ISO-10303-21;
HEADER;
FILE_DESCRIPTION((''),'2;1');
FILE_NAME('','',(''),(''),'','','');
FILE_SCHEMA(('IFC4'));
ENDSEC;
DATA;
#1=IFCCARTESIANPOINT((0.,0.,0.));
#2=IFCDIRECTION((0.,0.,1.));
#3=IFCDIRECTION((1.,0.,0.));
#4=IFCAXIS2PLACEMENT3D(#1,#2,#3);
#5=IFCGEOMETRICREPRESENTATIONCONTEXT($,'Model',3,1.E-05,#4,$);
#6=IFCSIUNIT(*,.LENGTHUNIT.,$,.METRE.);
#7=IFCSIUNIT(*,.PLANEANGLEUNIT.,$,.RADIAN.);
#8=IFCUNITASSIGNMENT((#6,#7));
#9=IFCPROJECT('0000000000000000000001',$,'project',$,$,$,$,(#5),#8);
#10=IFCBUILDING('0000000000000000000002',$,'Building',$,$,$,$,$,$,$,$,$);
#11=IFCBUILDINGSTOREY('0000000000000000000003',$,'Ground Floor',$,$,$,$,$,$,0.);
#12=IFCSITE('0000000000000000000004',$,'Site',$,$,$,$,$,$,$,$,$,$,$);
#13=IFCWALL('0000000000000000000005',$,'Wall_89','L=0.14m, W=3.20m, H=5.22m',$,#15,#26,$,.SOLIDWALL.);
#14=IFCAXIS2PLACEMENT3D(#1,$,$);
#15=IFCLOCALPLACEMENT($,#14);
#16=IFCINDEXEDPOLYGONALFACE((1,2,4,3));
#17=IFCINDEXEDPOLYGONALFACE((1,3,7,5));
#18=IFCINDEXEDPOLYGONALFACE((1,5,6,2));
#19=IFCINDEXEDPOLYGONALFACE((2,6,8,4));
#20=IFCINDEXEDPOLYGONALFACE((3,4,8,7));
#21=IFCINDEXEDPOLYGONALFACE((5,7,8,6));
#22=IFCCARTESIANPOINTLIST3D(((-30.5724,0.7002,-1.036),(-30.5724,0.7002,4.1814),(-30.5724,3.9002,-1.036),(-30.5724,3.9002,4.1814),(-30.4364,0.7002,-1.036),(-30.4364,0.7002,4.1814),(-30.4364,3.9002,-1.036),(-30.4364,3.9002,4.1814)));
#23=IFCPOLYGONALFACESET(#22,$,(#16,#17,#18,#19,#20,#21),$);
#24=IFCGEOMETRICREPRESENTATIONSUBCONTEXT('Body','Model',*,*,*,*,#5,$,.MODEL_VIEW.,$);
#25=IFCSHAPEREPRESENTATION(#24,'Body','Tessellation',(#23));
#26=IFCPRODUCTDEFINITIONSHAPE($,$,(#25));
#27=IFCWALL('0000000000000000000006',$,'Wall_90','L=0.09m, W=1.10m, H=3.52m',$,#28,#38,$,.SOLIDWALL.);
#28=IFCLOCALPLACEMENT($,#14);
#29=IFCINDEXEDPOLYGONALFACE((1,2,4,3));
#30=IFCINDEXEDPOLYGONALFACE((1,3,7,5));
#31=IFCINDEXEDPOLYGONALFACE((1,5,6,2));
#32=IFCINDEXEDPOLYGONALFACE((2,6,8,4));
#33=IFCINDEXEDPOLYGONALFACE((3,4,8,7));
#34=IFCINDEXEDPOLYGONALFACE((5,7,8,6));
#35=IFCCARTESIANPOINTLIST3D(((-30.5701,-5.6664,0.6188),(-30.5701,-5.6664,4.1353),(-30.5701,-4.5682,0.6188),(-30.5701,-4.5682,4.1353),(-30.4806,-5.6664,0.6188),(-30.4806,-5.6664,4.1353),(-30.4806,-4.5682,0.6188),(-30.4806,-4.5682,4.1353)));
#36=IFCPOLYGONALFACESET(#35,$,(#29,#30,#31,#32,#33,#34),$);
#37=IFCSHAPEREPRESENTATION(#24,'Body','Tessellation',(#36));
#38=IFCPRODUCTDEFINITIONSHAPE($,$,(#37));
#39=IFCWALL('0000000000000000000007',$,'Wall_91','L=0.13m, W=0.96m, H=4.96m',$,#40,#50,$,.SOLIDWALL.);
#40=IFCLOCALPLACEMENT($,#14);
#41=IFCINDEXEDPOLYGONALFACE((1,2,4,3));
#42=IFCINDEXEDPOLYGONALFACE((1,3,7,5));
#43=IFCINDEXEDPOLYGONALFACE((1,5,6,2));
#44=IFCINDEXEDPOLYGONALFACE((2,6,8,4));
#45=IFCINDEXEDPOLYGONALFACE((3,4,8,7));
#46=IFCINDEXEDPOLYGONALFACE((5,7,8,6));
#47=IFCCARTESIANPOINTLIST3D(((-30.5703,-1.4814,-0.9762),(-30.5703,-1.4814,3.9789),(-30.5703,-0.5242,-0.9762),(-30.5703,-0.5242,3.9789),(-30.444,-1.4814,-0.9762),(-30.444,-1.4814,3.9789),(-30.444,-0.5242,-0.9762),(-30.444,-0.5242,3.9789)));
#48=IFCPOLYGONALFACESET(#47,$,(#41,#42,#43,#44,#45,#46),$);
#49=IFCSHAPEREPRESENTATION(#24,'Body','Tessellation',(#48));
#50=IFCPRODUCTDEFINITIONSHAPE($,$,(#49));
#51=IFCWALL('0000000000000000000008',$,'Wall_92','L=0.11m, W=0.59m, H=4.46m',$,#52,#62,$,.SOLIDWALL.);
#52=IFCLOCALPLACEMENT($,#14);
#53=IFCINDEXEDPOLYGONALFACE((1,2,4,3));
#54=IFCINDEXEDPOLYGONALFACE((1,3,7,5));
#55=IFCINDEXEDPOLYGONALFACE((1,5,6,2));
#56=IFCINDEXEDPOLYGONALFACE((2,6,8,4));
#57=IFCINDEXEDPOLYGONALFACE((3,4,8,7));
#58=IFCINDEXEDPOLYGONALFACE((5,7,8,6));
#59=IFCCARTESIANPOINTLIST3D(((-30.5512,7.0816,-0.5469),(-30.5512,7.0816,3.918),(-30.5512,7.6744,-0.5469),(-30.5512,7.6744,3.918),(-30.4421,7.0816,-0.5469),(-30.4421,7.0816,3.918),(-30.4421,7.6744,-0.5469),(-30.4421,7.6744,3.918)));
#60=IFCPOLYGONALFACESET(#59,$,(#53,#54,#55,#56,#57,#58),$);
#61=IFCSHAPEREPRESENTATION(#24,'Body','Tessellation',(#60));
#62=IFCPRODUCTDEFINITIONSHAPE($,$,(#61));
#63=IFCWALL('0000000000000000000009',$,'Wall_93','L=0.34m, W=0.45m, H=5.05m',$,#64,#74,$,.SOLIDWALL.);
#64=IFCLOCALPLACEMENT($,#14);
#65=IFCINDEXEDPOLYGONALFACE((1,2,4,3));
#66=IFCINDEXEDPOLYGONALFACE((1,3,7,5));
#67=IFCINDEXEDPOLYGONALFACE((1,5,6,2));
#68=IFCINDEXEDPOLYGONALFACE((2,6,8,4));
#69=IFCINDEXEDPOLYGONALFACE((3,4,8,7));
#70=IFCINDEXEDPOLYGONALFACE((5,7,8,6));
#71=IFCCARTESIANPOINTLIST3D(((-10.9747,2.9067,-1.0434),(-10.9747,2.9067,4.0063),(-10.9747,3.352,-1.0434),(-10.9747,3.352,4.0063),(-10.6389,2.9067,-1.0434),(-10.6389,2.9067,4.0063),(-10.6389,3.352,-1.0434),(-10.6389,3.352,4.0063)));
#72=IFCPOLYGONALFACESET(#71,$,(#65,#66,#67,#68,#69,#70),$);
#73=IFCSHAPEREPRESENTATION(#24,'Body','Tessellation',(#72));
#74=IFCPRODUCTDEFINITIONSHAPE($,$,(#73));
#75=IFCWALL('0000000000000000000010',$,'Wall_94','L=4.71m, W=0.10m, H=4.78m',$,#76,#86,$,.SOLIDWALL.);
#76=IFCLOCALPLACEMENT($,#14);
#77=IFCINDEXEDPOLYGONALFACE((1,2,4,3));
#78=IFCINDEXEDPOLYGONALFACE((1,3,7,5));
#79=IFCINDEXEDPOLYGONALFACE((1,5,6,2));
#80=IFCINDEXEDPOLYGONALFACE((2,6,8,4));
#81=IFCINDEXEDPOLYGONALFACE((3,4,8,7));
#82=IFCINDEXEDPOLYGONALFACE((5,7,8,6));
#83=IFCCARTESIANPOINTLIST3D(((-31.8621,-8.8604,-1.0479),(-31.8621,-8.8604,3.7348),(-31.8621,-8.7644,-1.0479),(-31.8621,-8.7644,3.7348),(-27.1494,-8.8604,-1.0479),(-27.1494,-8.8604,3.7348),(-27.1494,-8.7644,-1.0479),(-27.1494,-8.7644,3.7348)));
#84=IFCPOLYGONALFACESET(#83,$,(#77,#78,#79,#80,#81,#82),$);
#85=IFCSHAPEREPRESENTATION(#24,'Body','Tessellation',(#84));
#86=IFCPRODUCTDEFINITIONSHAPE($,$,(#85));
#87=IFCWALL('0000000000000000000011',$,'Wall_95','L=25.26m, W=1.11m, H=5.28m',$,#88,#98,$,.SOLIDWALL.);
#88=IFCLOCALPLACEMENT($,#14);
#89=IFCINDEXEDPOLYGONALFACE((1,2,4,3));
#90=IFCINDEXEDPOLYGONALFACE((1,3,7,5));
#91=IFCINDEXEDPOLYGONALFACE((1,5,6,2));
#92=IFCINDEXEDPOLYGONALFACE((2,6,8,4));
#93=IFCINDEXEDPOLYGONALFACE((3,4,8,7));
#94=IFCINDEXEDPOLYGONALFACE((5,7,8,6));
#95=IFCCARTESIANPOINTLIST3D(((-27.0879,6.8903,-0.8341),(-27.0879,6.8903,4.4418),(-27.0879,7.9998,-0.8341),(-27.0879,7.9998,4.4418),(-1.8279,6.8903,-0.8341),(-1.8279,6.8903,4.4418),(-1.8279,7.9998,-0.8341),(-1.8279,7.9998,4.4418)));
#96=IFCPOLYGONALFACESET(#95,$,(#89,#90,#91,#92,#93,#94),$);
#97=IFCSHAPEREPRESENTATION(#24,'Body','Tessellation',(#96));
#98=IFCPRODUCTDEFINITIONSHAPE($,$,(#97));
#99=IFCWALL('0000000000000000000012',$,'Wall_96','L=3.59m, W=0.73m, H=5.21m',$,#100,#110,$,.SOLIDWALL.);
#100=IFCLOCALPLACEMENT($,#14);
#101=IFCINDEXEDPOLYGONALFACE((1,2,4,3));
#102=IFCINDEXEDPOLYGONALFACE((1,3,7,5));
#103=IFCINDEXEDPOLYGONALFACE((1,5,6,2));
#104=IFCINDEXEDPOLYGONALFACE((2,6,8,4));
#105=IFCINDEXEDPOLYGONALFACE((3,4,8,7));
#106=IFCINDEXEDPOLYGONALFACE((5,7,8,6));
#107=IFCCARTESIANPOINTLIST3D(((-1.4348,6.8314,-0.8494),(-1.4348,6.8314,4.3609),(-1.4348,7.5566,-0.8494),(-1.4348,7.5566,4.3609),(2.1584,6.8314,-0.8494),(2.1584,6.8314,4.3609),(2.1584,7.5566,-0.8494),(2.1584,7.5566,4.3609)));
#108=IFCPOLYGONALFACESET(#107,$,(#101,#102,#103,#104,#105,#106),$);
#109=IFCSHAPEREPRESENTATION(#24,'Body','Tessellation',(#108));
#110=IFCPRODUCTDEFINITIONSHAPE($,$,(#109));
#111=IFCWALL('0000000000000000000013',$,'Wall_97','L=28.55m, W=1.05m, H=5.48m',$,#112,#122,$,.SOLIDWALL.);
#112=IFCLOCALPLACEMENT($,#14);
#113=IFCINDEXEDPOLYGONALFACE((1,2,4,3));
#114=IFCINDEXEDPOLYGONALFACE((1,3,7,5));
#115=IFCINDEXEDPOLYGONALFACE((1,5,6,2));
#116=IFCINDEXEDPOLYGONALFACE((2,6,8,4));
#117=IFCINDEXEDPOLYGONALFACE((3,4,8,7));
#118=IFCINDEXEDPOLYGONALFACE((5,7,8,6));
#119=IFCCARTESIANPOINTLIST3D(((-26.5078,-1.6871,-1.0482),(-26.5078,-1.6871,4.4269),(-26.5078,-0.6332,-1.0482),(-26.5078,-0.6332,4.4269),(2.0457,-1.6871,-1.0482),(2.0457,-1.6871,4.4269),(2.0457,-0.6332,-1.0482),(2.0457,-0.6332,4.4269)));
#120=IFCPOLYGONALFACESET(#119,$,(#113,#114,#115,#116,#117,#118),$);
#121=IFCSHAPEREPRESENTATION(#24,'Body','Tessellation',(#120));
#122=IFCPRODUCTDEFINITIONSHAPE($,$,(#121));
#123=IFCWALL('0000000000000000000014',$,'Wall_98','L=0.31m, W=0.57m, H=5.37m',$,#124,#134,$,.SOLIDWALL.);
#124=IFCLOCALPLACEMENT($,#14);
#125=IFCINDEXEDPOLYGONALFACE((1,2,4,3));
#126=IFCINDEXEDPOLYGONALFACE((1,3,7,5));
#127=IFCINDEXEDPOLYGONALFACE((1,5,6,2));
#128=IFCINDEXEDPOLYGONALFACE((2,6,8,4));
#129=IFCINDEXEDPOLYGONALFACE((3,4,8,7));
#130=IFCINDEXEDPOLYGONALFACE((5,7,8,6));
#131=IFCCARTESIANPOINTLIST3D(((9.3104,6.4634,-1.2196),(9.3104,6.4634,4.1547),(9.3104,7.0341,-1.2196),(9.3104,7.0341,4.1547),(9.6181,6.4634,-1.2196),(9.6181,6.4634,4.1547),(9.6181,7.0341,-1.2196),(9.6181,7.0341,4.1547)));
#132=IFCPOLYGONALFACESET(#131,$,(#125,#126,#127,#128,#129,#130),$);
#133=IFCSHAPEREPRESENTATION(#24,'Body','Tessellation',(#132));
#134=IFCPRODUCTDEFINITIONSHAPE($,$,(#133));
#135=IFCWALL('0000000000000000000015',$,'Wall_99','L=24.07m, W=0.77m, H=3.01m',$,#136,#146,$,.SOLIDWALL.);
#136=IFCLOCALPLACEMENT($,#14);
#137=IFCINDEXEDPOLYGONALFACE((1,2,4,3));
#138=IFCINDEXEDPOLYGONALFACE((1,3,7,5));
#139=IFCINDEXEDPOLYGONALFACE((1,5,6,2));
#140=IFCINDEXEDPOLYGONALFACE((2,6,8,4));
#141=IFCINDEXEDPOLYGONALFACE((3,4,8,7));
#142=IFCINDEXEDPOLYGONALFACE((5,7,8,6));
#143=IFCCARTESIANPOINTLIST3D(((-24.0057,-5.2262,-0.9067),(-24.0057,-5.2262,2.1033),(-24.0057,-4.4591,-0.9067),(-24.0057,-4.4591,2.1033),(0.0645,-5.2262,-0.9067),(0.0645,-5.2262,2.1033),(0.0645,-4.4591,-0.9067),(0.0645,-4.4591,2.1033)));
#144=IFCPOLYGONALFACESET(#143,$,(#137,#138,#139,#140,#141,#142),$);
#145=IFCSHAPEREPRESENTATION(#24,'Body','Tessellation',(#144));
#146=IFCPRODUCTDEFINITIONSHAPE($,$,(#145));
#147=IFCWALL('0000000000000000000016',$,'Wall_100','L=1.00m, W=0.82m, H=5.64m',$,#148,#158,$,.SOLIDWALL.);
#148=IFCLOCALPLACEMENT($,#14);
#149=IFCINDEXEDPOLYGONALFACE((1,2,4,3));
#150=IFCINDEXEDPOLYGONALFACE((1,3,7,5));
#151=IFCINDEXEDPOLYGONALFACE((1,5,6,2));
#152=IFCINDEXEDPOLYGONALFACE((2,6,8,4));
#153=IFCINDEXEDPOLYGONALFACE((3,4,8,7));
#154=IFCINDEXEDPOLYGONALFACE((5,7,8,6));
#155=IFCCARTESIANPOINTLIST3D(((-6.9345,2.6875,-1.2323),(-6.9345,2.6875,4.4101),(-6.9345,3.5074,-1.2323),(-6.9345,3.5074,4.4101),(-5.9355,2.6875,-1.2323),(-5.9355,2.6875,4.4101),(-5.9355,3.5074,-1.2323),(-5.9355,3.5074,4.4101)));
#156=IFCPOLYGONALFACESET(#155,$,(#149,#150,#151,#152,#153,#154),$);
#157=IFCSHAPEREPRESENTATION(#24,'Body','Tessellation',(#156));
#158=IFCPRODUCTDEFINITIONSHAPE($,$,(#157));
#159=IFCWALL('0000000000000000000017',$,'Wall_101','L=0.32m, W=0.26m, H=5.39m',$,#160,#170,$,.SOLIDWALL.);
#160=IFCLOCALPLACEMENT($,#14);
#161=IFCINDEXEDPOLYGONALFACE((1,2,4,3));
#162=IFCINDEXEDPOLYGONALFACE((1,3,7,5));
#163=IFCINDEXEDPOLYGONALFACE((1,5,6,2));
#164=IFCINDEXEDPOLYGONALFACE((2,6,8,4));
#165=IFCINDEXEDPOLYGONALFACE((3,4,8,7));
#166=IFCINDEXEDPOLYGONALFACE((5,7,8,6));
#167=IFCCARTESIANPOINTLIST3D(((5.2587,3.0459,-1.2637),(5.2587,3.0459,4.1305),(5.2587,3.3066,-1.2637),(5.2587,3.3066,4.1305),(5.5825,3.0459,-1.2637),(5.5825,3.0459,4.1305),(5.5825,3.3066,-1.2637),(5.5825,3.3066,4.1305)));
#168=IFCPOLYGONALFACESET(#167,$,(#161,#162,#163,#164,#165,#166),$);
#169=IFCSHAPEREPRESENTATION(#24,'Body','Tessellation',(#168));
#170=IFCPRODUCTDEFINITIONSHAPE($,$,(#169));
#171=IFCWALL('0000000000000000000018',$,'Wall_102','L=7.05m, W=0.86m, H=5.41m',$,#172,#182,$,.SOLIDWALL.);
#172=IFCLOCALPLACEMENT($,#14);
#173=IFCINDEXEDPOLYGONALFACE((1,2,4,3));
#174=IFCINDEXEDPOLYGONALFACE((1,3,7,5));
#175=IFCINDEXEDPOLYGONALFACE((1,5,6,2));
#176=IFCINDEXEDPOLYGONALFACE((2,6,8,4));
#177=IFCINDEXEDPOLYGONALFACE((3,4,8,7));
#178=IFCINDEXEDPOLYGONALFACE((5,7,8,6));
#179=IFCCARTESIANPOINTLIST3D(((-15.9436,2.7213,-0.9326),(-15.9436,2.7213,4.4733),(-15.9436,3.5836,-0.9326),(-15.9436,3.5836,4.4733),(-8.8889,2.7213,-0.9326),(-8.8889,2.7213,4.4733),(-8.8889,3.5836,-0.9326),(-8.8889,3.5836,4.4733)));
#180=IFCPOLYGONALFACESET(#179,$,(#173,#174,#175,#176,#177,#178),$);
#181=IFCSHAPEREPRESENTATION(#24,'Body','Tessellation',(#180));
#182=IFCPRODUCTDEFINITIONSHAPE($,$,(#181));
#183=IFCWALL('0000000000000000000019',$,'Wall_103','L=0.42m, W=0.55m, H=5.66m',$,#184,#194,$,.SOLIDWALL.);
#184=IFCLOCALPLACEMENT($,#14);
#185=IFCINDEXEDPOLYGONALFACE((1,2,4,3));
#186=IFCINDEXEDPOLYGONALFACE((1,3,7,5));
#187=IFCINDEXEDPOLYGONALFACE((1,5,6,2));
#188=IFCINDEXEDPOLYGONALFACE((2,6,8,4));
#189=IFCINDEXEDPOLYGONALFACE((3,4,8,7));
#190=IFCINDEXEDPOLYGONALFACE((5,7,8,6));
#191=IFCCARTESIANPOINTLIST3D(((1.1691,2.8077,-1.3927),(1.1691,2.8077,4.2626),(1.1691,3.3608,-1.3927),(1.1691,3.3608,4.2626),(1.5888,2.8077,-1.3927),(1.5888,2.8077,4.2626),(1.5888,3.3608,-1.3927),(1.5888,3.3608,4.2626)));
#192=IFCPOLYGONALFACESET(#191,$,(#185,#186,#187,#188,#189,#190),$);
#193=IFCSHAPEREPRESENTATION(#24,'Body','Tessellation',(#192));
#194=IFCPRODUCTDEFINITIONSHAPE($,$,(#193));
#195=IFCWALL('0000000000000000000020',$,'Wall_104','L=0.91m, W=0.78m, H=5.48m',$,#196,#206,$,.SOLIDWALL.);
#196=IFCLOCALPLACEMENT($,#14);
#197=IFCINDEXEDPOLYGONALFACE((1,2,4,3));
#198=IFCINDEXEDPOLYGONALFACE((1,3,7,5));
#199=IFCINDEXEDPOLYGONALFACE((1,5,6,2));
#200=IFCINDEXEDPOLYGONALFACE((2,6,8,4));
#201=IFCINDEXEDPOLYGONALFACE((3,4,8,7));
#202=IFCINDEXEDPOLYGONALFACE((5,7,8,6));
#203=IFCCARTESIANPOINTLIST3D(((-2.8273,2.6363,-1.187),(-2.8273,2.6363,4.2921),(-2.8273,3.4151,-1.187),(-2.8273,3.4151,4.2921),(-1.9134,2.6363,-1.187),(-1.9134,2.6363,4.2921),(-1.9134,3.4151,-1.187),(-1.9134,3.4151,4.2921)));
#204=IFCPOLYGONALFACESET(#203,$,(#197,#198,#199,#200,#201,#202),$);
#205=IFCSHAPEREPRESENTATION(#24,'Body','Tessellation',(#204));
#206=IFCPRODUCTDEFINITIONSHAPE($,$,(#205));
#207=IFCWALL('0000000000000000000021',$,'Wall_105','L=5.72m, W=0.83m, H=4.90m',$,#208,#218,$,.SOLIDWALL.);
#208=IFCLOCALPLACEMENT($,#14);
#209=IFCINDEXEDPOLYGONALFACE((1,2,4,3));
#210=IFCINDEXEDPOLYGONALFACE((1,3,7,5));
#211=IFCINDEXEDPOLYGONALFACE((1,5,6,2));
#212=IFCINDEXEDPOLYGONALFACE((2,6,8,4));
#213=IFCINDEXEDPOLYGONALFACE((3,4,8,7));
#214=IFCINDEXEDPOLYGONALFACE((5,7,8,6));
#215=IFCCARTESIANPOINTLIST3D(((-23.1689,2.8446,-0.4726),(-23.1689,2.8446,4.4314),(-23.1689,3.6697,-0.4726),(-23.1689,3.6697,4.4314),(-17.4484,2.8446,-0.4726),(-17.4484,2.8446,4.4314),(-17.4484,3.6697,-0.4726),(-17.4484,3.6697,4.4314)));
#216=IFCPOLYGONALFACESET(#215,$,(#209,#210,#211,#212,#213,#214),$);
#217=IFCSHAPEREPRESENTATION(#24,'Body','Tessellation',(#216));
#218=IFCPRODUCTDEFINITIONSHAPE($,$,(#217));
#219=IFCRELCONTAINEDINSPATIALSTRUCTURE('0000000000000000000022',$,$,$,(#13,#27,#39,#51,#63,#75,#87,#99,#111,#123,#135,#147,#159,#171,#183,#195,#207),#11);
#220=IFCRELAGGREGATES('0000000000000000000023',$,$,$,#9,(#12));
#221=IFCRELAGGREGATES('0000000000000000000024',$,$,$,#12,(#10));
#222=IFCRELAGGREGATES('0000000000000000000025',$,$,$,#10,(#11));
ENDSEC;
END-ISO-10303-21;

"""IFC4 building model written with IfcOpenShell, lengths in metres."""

from ifc_helpers import new_model, si_unit, frame, origin_with_axes, origin_2d, context, subcontext, project, spatial, rectangle, extrude, element, save


model = new_model("IFC4")

# Units and contexts
model_context = context("Model", 3, precision=1e-05, world=origin_with_axes())
body_context = subcontext(model_context, "Body", "Model", "MODEL_VIEW")
ifc_project = project(units=[si_unit("LENGTHUNIT", "METRE"), si_unit("PLANEANGLEUNIT", "RADIAN")], contexts=[model_context])

# Site, building, storey
site = spatial("IfcSite", under=ifc_project, Name="Site")
building = spatial("IfcBuilding", under=site, Name="Building")
storey = spatial("IfcBuildingStorey", under=building, Name="Ground Floor", Elevation=0.0)

# Walls
element("IfcWall", 1, inside=storey, Name="Wall_89", Description="L=0.14m, W=3.20m, H=5.22m", PredefinedType="SOLIDWALL", context=body_context, shape_type="SweptSolid", body=[
    extrude(rectangle(XDim=0.136, YDim=3.2, at=origin_2d()), frame((-30.5044, 2.3002, -1.036), z_axis=(0.0, 0.0, 1.0), x_axis=(1.0, 0.0, 0.0)), (0.0, 0.0, 1.0), 5.2174),
])
element("IfcWall", 2, inside=storey, Name="Wall_90", Description="L=0.09m, W=1.10m, H=3.52m", PredefinedType="SOLIDWALL", context=body_context, shape_type="SweptSolid", body=[
    extrude(rectangle(XDim=0.0895, YDim=1.0983, at=origin_2d()), frame((-30.5254, -5.1173, 0.6188), z_axis=(0.0, 0.0, 1.0), x_axis=(1.0, 0.0, 0.0)), (0.0, 0.0, 1.0), 3.5166),
])
element("IfcWall", 3, inside=storey, Name="Wall_91", Description="L=0.13m, W=0.96m, H=4.96m", PredefinedType="SOLIDWALL", context=body_context, shape_type="SweptSolid", body=[
    extrude(rectangle(XDim=0.1263, YDim=0.9571, at=origin_2d()), frame((-30.5071, -1.0028, -0.9762), z_axis=(0.0, 0.0, 1.0), x_axis=(1.0, 0.0, 0.0)), (0.0, 0.0, 1.0), 4.9551),
])
element("IfcWall", 4, inside=storey, Name="Wall_92", Description="L=0.11m, W=0.59m, H=4.46m", PredefinedType="SOLIDWALL", context=body_context, shape_type="SweptSolid", body=[
    extrude(rectangle(XDim=0.1091, YDim=0.5928, at=origin_2d()), frame((-30.4967, 7.378, -0.5469), z_axis=(0.0, 0.0, 1.0), x_axis=(1.0, 0.0, 0.0)), (0.0, 0.0, 1.0), 4.4649),
])
element("IfcWall", 5, inside=storey, Name="Wall_93", Description="L=0.34m, W=0.45m, H=5.05m", PredefinedType="SOLIDWALL", context=body_context, shape_type="SweptSolid", body=[
    extrude(rectangle(XDim=0.3358, YDim=0.4454, at=origin_2d()), frame((-10.8068, 3.1293, -1.0434), z_axis=(0.0, 0.0, 1.0), x_axis=(1.0, 0.0, 0.0)), (0.0, 0.0, 1.0), 5.0497),
])
element("IfcWall", 6, inside=storey, Name="Wall_94", Description="L=4.71m, W=0.10m, H=4.78m", PredefinedType="SOLIDWALL", context=body_context, shape_type="SweptSolid", body=[
    extrude(rectangle(XDim=4.7127, YDim=0.0959, at=origin_2d()), frame((-29.5058, -8.8124, -1.0479), z_axis=(0.0, 0.0, 1.0), x_axis=(1.0, 0.0, 0.0)), (0.0, 0.0, 1.0), 4.7827),
])
element("IfcWall", 7, inside=storey, Name="Wall_95", Description="L=25.26m, W=1.11m, H=5.28m", PredefinedType="SOLIDWALL", context=body_context, shape_type="SweptSolid", body=[
    extrude(rectangle(XDim=25.26, YDim=1.1095, at=origin_2d()), frame((-14.4579, 7.4451, -0.8341), z_axis=(0.0, 0.0, 1.0), x_axis=(1.0, 0.0, 0.0)), (0.0, 0.0, 1.0), 5.276),
])
element("IfcWall", 8, inside=storey, Name="Wall_96", Description="L=3.59m, W=0.73m, H=5.21m", PredefinedType="SOLIDWALL", context=body_context, shape_type="SweptSolid", body=[
    extrude(rectangle(XDim=3.5931, YDim=0.7253, at=origin_2d()), frame((0.3618, 7.194, -0.8494), z_axis=(0.0, 0.0, 1.0), x_axis=(1.0, 0.0, 0.0)), (0.0, 0.0, 1.0), 5.2103),
])
element("IfcWall", 9, inside=storey, Name="Wall_97", Description="L=28.55m, W=1.05m, H=5.48m", PredefinedType="SOLIDWALL", context=body_context, shape_type="SweptSolid", body=[
    extrude(rectangle(XDim=28.5534, YDim=1.0539, at=origin_2d()), frame((-12.231, -1.1601, -1.0482), z_axis=(0.0, 0.0, 1.0), x_axis=(1.0, 0.0, 0.0)), (0.0, 0.0, 1.0), 5.4752),
])
element("IfcWall", 10, inside=storey, Name="Wall_98", Description="L=0.31m, W=0.57m, H=5.37m", PredefinedType="SOLIDWALL", context=body_context, shape_type="SweptSolid", body=[
    extrude(rectangle(XDim=0.3077, YDim=0.5707, at=origin_2d()), frame((9.4642, 6.7487, -1.2196), z_axis=(0.0, 0.0, 1.0), x_axis=(1.0, 0.0, 0.0)), (0.0, 0.0, 1.0), 5.3743),
])
element("IfcWall", 11, inside=storey, Name="Wall_99", Description="L=24.07m, W=0.77m, H=3.01m", PredefinedType="SOLIDWALL", context=body_context, shape_type="SweptSolid", body=[
    extrude(rectangle(XDim=24.0702, YDim=0.7671, at=origin_2d()), frame((-11.9706, -4.8426, -0.9067), z_axis=(0.0, 0.0, 1.0), x_axis=(1.0, 0.0, 0.0)), (0.0, 0.0, 1.0), 3.01),
])
element("IfcWall", 12, inside=storey, Name="Wall_100", Description="L=1.00m, W=0.82m, H=5.64m", PredefinedType="SOLIDWALL", context=body_context, shape_type="SweptSolid", body=[
    extrude(rectangle(XDim=0.999, YDim=0.8198, at=origin_2d()), frame((-6.435, 3.0974, -1.2323), z_axis=(0.0, 0.0, 1.0), x_axis=(1.0, 0.0, 0.0)), (0.0, 0.0, 1.0), 5.6424),
])
element("IfcWall", 13, inside=storey, Name="Wall_101", Description="L=0.32m, W=0.26m, H=5.39m", PredefinedType="SOLIDWALL", context=body_context, shape_type="SweptSolid", body=[
    extrude(rectangle(XDim=0.3237, YDim=0.2606, at=origin_2d()), frame((5.4206, 3.1763, -1.2637), z_axis=(0.0, 0.0, 1.0), x_axis=(1.0, 0.0, 0.0)), (0.0, 0.0, 1.0), 5.3941),
])
element("IfcWall", 14, inside=storey, Name="Wall_102", Description="L=7.05m, W=0.86m, H=5.41m", PredefinedType="SOLIDWALL", context=body_context, shape_type="SweptSolid", body=[
    extrude(rectangle(XDim=7.0547, YDim=0.8623, at=origin_2d()), frame((-12.4163, 3.1524, -0.9326), z_axis=(0.0, 0.0, 1.0), x_axis=(1.0, 0.0, 0.0)), (0.0, 0.0, 1.0), 5.4059),
])
element("IfcWall", 15, inside=storey, Name="Wall_103", Description="L=0.42m, W=0.55m, H=5.66m", PredefinedType="SOLIDWALL", context=body_context, shape_type="SweptSolid", body=[
    extrude(rectangle(XDim=0.4197, YDim=0.5531, at=origin_2d()), frame((1.379, 3.0842, -1.3927), z_axis=(0.0, 0.0, 1.0), x_axis=(1.0, 0.0, 0.0)), (0.0, 0.0, 1.0), 5.6553),
])
element("IfcWall", 16, inside=storey, Name="Wall_104", Description="L=0.91m, W=0.78m, H=5.48m", PredefinedType="SOLIDWALL", context=body_context, shape_type="SweptSolid", body=[
    extrude(rectangle(XDim=0.9138, YDim=0.7788, at=origin_2d()), frame((-2.3703, 3.0257, -1.187), z_axis=(0.0, 0.0, 1.0), x_axis=(1.0, 0.0, 0.0)), (0.0, 0.0, 1.0), 5.4791),
])
element("IfcWall", 17, inside=storey, Name="Wall_105", Description="L=5.72m, W=0.83m, H=4.90m", PredefinedType="SOLIDWALL", context=body_context, shape_type="SweptSolid", body=[
    extrude(rectangle(XDim=5.7205, YDim=0.8251, at=origin_2d()), frame((-20.3086, 3.2571, -0.4726), z_axis=(0.0, 0.0, 1.0), x_axis=(1.0, 0.0, 0.0)), (0.0, 0.0, 1.0), 4.9039),
])

save(model, "model.ifc")
